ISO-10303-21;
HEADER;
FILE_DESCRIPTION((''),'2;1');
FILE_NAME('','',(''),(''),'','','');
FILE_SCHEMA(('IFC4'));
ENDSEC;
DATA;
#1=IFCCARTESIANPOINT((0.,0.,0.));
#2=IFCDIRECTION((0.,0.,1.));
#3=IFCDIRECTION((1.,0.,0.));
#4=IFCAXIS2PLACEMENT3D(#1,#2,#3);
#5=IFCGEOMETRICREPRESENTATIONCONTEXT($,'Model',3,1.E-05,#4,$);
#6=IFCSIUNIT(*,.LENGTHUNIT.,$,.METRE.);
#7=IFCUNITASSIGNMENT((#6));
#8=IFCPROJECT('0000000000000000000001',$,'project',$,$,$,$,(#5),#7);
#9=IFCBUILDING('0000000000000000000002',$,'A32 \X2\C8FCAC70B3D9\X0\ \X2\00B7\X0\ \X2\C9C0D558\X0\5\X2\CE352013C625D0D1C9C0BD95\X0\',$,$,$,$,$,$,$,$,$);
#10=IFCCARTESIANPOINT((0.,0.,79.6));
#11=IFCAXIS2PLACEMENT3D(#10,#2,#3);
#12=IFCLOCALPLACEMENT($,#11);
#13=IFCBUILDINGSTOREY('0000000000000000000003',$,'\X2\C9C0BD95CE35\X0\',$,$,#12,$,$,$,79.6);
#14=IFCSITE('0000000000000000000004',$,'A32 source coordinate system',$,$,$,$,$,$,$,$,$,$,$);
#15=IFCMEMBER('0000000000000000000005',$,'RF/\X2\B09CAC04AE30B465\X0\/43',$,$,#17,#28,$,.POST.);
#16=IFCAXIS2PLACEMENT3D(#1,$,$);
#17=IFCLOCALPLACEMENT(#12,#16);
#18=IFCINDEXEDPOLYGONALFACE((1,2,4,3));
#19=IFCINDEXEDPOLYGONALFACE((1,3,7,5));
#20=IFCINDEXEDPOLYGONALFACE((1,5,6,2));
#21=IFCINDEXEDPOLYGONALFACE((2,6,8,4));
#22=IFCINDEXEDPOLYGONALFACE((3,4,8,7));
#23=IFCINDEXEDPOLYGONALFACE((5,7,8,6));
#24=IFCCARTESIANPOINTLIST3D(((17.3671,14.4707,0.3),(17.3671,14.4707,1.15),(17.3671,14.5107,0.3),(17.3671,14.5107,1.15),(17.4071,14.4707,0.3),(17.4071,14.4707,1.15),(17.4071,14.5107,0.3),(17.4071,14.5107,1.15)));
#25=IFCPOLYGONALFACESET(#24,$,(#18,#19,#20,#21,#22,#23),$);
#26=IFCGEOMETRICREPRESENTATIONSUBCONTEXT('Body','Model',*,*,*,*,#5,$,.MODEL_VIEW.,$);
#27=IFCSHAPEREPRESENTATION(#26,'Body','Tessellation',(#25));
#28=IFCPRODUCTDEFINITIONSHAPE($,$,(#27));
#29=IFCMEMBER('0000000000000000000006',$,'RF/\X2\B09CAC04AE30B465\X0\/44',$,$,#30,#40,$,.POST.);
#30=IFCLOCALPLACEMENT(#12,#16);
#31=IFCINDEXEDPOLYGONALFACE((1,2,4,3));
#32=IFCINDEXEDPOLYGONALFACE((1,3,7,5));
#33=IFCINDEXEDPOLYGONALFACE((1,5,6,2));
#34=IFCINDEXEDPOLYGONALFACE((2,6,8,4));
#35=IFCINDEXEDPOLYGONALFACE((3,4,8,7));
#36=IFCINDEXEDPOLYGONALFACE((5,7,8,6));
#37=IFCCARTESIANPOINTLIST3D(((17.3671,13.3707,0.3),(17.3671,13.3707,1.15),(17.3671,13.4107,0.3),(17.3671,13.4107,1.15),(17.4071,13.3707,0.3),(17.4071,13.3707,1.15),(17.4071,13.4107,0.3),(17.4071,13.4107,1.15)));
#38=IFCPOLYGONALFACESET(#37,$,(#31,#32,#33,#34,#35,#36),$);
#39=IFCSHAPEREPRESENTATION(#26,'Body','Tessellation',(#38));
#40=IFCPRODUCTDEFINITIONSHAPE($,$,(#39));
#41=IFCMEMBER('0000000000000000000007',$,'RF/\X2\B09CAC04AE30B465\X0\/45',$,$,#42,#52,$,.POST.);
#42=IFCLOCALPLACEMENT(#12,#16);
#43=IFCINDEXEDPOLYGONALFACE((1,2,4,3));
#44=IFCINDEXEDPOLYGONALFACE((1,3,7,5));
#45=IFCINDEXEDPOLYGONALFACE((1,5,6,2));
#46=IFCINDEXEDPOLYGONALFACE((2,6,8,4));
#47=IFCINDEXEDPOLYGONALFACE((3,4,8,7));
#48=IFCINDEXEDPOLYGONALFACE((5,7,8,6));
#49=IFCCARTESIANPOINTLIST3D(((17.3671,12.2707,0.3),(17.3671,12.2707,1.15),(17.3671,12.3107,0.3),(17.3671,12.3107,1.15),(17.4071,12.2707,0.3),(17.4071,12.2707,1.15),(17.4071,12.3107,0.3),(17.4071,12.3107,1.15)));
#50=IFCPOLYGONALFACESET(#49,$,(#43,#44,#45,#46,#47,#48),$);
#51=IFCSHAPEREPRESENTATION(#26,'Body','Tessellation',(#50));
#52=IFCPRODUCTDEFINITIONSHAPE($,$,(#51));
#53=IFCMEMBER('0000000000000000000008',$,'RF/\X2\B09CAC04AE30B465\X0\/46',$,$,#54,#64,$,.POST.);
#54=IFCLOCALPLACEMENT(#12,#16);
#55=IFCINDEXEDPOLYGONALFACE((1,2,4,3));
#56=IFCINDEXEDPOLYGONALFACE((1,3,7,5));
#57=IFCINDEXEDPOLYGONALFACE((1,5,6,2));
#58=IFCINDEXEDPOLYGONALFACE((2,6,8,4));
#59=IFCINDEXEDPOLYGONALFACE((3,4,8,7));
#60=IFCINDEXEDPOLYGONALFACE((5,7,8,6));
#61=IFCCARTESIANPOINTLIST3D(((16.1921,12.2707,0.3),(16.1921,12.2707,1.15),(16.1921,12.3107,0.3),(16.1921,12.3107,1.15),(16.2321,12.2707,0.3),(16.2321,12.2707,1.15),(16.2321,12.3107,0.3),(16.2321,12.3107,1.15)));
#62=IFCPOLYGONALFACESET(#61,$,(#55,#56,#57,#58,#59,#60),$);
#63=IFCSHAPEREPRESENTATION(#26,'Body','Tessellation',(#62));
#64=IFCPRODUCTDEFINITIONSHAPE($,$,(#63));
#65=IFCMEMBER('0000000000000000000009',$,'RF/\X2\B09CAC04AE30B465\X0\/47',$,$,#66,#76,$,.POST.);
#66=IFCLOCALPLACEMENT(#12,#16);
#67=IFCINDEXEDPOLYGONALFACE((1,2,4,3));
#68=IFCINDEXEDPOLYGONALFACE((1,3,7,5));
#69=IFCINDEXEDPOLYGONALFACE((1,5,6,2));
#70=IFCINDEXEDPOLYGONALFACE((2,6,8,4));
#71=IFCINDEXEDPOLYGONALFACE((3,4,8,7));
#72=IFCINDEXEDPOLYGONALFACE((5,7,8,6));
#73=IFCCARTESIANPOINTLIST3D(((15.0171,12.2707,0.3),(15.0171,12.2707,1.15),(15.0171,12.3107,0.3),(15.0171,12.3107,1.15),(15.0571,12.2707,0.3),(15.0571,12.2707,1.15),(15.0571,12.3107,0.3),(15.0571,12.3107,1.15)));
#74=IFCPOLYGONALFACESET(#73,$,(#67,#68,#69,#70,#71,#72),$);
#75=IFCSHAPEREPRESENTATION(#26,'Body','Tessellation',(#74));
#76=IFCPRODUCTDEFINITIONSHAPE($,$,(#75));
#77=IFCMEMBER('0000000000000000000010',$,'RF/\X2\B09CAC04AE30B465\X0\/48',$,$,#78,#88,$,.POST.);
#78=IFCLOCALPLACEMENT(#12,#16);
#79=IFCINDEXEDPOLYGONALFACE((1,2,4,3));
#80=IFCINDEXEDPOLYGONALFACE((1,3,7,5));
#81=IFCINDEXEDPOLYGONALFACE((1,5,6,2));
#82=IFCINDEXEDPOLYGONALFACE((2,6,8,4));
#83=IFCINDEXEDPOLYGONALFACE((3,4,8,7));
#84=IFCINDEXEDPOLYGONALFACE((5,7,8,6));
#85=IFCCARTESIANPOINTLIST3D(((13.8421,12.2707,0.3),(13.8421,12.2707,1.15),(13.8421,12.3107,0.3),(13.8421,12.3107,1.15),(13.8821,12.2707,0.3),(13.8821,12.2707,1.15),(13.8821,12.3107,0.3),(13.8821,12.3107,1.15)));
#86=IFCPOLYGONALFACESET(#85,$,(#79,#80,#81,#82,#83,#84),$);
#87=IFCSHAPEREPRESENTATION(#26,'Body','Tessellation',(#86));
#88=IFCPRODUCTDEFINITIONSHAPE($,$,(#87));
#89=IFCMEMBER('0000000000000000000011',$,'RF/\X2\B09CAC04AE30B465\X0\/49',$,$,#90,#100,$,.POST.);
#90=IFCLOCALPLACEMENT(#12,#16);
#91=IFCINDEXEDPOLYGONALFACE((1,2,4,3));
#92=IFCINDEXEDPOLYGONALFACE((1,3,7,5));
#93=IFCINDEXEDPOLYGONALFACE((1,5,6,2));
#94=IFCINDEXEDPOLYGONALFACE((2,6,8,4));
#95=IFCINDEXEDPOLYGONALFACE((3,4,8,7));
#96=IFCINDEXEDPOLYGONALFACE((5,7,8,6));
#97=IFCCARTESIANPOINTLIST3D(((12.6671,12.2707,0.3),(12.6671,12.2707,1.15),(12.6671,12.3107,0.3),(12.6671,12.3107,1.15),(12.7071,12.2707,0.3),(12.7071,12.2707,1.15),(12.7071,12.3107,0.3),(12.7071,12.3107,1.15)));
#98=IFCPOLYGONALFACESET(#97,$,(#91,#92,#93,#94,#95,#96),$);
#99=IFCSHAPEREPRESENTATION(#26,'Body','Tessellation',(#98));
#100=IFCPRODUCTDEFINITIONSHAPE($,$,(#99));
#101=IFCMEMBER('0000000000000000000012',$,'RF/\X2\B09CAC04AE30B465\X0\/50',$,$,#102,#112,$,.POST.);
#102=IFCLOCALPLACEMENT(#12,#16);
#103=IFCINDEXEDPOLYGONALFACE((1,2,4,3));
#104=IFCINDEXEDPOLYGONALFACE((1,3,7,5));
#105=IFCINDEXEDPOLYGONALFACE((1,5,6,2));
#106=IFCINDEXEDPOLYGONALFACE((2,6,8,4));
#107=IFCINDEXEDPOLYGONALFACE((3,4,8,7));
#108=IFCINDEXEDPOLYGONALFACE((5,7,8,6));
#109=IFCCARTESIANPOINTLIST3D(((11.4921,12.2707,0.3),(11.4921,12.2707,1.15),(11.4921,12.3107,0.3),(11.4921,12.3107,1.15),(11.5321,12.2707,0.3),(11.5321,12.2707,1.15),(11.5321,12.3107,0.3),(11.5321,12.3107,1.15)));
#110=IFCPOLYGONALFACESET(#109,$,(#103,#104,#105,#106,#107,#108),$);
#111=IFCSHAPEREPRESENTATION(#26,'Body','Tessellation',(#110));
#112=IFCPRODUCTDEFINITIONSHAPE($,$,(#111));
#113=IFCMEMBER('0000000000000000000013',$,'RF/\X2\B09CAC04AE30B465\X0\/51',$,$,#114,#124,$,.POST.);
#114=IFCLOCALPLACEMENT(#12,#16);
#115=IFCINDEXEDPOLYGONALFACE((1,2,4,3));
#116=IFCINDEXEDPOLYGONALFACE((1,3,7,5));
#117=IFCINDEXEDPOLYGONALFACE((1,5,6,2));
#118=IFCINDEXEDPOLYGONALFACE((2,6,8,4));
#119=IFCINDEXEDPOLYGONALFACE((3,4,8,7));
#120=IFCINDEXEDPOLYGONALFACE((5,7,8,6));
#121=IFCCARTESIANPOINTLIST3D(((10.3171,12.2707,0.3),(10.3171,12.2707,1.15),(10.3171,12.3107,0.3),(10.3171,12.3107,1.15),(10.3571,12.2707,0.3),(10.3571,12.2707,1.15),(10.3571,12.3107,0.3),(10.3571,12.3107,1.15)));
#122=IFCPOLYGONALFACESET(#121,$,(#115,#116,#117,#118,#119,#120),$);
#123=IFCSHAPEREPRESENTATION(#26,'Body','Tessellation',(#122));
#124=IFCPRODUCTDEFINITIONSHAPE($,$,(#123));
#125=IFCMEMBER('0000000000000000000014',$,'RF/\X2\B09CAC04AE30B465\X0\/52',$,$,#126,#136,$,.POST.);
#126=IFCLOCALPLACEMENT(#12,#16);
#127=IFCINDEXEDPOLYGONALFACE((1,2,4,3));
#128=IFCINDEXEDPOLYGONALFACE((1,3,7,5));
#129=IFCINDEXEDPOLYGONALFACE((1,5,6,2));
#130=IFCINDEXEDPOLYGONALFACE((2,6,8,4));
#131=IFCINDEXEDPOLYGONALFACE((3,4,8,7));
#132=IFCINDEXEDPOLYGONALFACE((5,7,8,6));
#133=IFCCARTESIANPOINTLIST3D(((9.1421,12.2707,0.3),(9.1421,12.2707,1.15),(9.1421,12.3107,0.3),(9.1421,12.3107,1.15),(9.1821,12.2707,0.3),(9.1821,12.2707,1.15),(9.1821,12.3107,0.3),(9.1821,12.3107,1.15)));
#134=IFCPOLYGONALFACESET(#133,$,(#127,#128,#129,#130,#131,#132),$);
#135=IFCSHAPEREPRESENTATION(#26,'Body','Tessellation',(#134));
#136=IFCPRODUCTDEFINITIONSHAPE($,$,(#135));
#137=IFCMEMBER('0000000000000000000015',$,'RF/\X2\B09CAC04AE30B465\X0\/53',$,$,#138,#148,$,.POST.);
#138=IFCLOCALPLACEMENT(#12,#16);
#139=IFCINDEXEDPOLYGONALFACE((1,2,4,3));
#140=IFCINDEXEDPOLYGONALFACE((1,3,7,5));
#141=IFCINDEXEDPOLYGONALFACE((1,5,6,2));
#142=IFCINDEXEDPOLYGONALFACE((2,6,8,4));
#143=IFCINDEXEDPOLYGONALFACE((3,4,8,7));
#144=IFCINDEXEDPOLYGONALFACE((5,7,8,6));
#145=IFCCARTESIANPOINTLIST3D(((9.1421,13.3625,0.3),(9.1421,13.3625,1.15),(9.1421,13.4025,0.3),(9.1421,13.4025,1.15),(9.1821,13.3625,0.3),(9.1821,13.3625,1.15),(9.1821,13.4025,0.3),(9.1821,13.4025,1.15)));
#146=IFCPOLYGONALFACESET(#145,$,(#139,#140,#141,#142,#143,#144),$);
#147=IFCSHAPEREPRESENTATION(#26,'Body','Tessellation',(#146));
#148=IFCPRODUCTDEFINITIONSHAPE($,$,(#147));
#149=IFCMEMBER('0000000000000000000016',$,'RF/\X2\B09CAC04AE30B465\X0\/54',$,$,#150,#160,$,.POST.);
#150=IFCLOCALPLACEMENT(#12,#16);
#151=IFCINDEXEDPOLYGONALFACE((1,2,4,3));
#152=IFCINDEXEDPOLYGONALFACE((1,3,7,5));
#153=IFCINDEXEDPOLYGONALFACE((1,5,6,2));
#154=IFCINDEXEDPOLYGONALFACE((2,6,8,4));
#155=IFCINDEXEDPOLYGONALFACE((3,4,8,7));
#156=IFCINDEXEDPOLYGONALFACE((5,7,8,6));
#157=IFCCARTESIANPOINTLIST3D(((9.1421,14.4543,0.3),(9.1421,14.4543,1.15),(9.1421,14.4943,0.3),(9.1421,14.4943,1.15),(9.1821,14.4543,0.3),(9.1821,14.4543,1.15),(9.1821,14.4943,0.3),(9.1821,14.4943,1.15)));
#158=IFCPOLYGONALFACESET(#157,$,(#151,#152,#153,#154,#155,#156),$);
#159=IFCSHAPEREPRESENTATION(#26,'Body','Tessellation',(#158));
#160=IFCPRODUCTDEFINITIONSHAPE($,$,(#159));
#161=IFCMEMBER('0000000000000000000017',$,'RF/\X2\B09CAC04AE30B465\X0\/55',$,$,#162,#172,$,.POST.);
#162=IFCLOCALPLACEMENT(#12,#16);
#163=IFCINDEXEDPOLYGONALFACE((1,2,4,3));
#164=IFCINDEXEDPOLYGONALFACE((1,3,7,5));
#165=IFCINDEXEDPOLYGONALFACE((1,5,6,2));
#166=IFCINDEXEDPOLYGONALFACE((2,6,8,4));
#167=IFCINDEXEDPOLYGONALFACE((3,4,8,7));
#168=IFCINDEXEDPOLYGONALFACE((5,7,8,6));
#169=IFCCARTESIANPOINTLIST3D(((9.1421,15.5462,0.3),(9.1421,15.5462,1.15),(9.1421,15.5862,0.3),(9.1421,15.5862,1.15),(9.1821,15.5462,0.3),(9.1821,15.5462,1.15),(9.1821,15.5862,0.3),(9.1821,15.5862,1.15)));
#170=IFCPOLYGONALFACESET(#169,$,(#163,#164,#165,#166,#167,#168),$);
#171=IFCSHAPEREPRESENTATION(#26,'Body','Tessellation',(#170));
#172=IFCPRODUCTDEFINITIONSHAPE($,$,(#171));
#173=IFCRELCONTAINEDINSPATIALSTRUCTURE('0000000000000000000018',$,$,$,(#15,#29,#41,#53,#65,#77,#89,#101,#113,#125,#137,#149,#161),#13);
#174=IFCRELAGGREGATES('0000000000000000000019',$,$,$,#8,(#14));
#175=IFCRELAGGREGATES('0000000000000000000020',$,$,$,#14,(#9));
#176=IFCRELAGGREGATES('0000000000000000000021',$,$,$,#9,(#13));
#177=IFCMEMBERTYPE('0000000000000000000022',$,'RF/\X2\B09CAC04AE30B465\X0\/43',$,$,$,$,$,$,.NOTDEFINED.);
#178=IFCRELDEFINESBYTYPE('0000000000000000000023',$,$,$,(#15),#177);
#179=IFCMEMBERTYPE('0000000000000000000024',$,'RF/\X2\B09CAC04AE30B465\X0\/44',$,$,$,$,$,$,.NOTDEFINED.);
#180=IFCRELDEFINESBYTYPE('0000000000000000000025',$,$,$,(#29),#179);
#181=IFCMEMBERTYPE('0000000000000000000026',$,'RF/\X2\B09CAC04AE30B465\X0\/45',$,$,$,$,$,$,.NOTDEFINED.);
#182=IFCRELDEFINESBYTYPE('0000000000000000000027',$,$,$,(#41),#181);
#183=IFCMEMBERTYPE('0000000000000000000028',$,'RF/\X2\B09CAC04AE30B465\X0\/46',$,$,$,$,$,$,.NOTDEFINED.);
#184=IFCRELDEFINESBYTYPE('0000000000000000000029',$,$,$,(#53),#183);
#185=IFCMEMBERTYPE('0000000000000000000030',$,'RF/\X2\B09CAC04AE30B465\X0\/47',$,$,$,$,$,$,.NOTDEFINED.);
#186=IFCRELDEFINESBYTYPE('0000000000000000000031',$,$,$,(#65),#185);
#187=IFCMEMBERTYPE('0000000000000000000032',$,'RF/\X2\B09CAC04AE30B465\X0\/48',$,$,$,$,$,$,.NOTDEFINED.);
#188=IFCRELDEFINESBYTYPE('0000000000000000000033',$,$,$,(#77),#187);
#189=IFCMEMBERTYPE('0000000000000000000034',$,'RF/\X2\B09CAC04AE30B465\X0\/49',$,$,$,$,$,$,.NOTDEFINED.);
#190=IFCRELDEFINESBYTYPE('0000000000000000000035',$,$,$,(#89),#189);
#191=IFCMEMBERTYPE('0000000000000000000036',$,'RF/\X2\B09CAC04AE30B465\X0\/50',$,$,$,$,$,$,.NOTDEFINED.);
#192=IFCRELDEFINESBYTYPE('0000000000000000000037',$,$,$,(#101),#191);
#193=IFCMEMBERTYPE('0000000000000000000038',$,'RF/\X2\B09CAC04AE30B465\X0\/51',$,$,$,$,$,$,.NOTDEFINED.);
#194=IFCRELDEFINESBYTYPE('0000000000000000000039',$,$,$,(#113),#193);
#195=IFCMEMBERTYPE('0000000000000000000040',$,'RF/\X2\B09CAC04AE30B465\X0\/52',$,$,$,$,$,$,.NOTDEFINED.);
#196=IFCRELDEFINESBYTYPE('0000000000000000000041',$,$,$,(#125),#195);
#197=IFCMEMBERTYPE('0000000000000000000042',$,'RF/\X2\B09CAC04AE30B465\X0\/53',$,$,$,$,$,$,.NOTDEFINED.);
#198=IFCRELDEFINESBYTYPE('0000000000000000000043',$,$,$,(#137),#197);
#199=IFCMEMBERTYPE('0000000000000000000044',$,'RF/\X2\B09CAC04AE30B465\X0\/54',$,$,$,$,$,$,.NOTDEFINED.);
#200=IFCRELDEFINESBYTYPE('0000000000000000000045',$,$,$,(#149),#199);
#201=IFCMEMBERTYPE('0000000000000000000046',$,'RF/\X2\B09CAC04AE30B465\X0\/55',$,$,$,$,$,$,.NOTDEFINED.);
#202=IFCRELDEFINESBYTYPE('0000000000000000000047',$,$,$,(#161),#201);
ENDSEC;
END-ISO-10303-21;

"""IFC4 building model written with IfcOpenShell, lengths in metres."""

from ifc_helpers import new_model, si_unit, frame, origin, origin_with_axes, place, context, subcontext, project, spatial, polyline, outline, extrude, source, transform, mapped, type_object, type_shapes, element, save


model = new_model("IFC4")

# Units and contexts
model_context = context("Model", 3, precision=1e-05, world=origin_with_axes())
body_context = subcontext(model_context, "Body", "Model", "MODEL_VIEW")
ifc_project = project(units=[si_unit("LENGTHUNIT", "METRE")], contexts=[model_context])

# Site, building, storey
site = spatial("IfcSite", under=ifc_project, Name="A32 source coordinate system")
building = spatial("IfcBuilding", under=site, Name="A32 주거동 · 지하5층–옥탑지붕")
storey_placement = place(None, frame((0.0, 0.0, 79.6), z_axis=(0.0, 0.0, 1.0), x_axis=(1.0, 0.0, 0.0)))
storey = spatial("IfcBuildingStorey", under=building, at=storey_placement, Name="지붕층", Elevation=79.6)

# Members
member_type_1 = type_object("IfcMemberType", Name="RF/난간기둥/43", PredefinedType="NOTDEFINED")
shared_shape_1 = source(origin(), body_context, "Body", "SweptSolid", [
    extrude(outline(polyline([(17.4071, 14.4707), (17.3671, 14.4707), (17.3671, 14.5107), (17.4071, 14.5107), (17.4071, 14.4707)])), frame((0.0, 0.0, 0.3)), (0.0, 0.0, 1.0), 0.85),
])
type_shapes(member_type_1, [shared_shape_1])
member_1_placement = place(storey_placement, origin_with_axes())
element("IfcMember", 1, at=member_1_placement, inside=storey, type_object=member_type_1, Name="RF/난간기둥/43", PredefinedType="POST", context=body_context, shape_type="MappedRepresentation", body=[
    mapped(shared_shape_1, transform((0.0, 0.0, 0.0), scale=1.0)),
])
member_type_2 = type_object("IfcMemberType", Name="RF/난간기둥/44", PredefinedType="NOTDEFINED")
shared_shape_2 = source(origin(), body_context, "Body", "SweptSolid", [
    extrude(outline(polyline([(17.4071, 13.3707), (17.3671, 13.3707), (17.3671, 13.4107), (17.4071, 13.4107), (17.4071, 13.3707)])), frame((0.0, 0.0, 0.3)), (0.0, 0.0, 1.0), 0.85),
])
type_shapes(member_type_2, [shared_shape_2])
member_2_placement = place(storey_placement, origin_with_axes())
element("IfcMember", 2, at=member_2_placement, inside=storey, type_object=member_type_2, Name="RF/난간기둥/44", PredefinedType="POST", context=body_context, shape_type="MappedRepresentation", body=[
    mapped(shared_shape_2, transform((0.0, 0.0, 0.0), scale=1.0)),
])
member_type_3 = type_object("IfcMemberType", Name="RF/난간기둥/45", PredefinedType="NOTDEFINED")
shared_shape_3 = source(origin(), body_context, "Body", "SweptSolid", [
    extrude(outline(polyline([(17.4071, 12.2707), (17.3671, 12.2707), (17.3671, 12.3107), (17.4071, 12.3107), (17.4071, 12.2707)])), frame((0.0, 0.0, 0.3)), (0.0, 0.0, 1.0), 0.85),
])
type_shapes(member_type_3, [shared_shape_3])
member_3_placement = place(storey_placement, origin_with_axes())
element("IfcMember", 3, at=member_3_placement, inside=storey, type_object=member_type_3, Name="RF/난간기둥/45", PredefinedType="POST", context=body_context, shape_type="MappedRepresentation", body=[
    mapped(shared_shape_3, transform((0.0, 0.0, 0.0), scale=1.0)),
])
member_type_4 = type_object("IfcMemberType", Name="RF/난간기둥/46", PredefinedType="NOTDEFINED")
shared_shape_4 = source(origin(), body_context, "Body", "SweptSolid", [
    extrude(outline(polyline([(16.2321, 12.2707), (16.1921, 12.2707), (16.1921, 12.3107), (16.2321, 12.3107), (16.2321, 12.2707)])), frame((0.0, 0.0, 0.3)), (0.0, 0.0, 1.0), 0.85),
])
type_shapes(member_type_4, [shared_shape_4])
member_4_placement = place(storey_placement, origin_with_axes())
element("IfcMember", 4, at=member_4_placement, inside=storey, type_object=member_type_4, Name="RF/난간기둥/46", PredefinedType="POST", context=body_context, shape_type="MappedRepresentation", body=[
    mapped(shared_shape_4, transform((0.0, 0.0, 0.0), scale=1.0)),
])
member_type_5 = type_object("IfcMemberType", Name="RF/난간기둥/47", PredefinedType="NOTDEFINED")
shared_shape_5 = source(origin(), body_context, "Body", "SweptSolid", [
    extrude(outline(polyline([(15.0571, 12.2707), (15.0171, 12.2707), (15.0171, 12.3107), (15.0571, 12.3107), (15.0571, 12.2707)])), frame((0.0, 0.0, 0.3)), (0.0, 0.0, 1.0), 0.85),
])
type_shapes(member_type_5, [shared_shape_5])
member_5_placement = place(storey_placement, origin_with_axes())
element("IfcMember", 5, at=member_5_placement, inside=storey, type_object=member_type_5, Name="RF/난간기둥/47", PredefinedType="POST", context=body_context, shape_type="MappedRepresentation", body=[
    mapped(shared_shape_5, transform((0.0, 0.0, 0.0), scale=1.0)),
])
member_type_6 = type_object("IfcMemberType", Name="RF/난간기둥/48", PredefinedType="NOTDEFINED")
shared_shape_6 = source(origin(), body_context, "Body", "SweptSolid", [
    extrude(outline(polyline([(13.8821, 12.2707), (13.8421, 12.2707), (13.8421, 12.3107), (13.8821, 12.3107), (13.8821, 12.2707)])), frame((0.0, 0.0, 0.3)), (0.0, 0.0, 1.0), 0.85),
])
type_shapes(member_type_6, [shared_shape_6])
member_6_placement = place(storey_placement, origin_with_axes())
element("IfcMember", 6, at=member_6_placement, inside=storey, type_object=member_type_6, Name="RF/난간기둥/48", PredefinedType="POST", context=body_context, shape_type="MappedRepresentation", body=[
    mapped(shared_shape_6, transform((0.0, 0.0, 0.0), scale=1.0)),
])
member_type_7 = type_object("IfcMemberType", Name="RF/난간기둥/49", PredefinedType="NOTDEFINED")
shared_shape_7 = source(origin(), body_context, "Body", "SweptSolid", [
    extrude(outline(polyline([(12.7071, 12.2707), (12.6671, 12.2707), (12.6671, 12.3107), (12.7071, 12.3107), (12.7071, 12.2707)])), frame((0.0, 0.0, 0.3)), (0.0, 0.0, 1.0), 0.85),
])
type_shapes(member_type_7, [shared_shape_7])
member_7_placement = place(storey_placement, origin_with_axes())
element("IfcMember", 7, at=member_7_placement, inside=storey, type_object=member_type_7, Name="RF/난간기둥/49", PredefinedType="POST", context=body_context, shape_type="MappedRepresentation", body=[
    mapped(shared_shape_7, transform((0.0, 0.0, 0.0), scale=1.0)),
])
member_type_8 = type_object("IfcMemberType", Name="RF/난간기둥/50", PredefinedType="NOTDEFINED")
shared_shape_8 = source(origin(), body_context, "Body", "SweptSolid", [
    extrude(outline(polyline([(11.5321, 12.2707), (11.4921, 12.2707), (11.4921, 12.3107), (11.5321, 12.3107), (11.5321, 12.2707)])), frame((0.0, 0.0, 0.3)), (0.0, 0.0, 1.0), 0.85),
])
type_shapes(member_type_8, [shared_shape_8])
member_8_placement = place(storey_placement, origin_with_axes())
element("IfcMember", 8, at=member_8_placement, inside=storey, type_object=member_type_8, Name="RF/난간기둥/50", PredefinedType="POST", context=body_context, shape_type="MappedRepresentation", body=[
    mapped(shared_shape_8, transform((0.0, 0.0, 0.0), scale=1.0)),
])
member_type_9 = type_object("IfcMemberType", Name="RF/난간기둥/51", PredefinedType="NOTDEFINED")
shared_shape_9 = source(origin(), body_context, "Body", "SweptSolid", [
    extrude(outline(polyline([(10.3571, 12.2707), (10.3171, 12.2707), (10.3171, 12.3107), (10.3571, 12.3107), (10.3571, 12.2707)])), frame((0.0, 0.0, 0.3)), (0.0, 0.0, 1.0), 0.85),
])
type_shapes(member_type_9, [shared_shape_9])
member_9_placement = place(storey_placement, origin_with_axes())
element("IfcMember", 9, at=member_9_placement, inside=storey, type_object=member_type_9, Name="RF/난간기둥/51", PredefinedType="POST", context=body_context, shape_type="MappedRepresentation", body=[
    mapped(shared_shape_9, transform((0.0, 0.0, 0.0), scale=1.0)),
])
member_type_10 = type_object("IfcMemberType", Name="RF/난간기둥/52", PredefinedType="NOTDEFINED")
shared_shape_10 = source(origin(), body_context, "Body", "SweptSolid", [
    extrude(outline(polyline([(9.1821, 12.2707), (9.1421, 12.2707), (9.1421, 12.3107), (9.1821, 12.3107), (9.1821, 12.2707)])), frame((0.0, 0.0, 0.3)), (0.0, 0.0, 1.0), 0.85),
])
type_shapes(member_type_10, [shared_shape_10])
member_10_placement = place(storey_placement, origin_with_axes())
element("IfcMember", 10, at=member_10_placement, inside=storey, type_object=member_type_10, Name="RF/난간기둥/52", PredefinedType="POST", context=body_context, shape_type="MappedRepresentation", body=[
    mapped(shared_shape_10, transform((0.0, 0.0, 0.0), scale=1.0)),
])
member_type_11 = type_object("IfcMemberType", Name="RF/난간기둥/53", PredefinedType="NOTDEFINED")
shared_shape_11 = source(origin(), body_context, "Body", "SweptSolid", [
    extrude(outline(polyline([(9.1821, 13.3625), (9.1421, 13.3625), (9.1421, 13.4025), (9.1821, 13.4025), (9.1821, 13.3625)])), frame((0.0, 0.0, 0.3)), (0.0, 0.0, 1.0), 0.85),
])
type_shapes(member_type_11, [shared_shape_11])
member_11_placement = place(storey_placement, origin_with_axes())
element("IfcMember", 11, at=member_11_placement, inside=storey, type_object=member_type_11, Name="RF/난간기둥/53", PredefinedType="POST", context=body_context, shape_type="MappedRepresentation", body=[
    mapped(shared_shape_11, transform((0.0, 0.0, 0.0), scale=1.0)),
])
member_type_12 = type_object("IfcMemberType", Name="RF/난간기둥/54", PredefinedType="NOTDEFINED")
shared_shape_12 = source(origin(), body_context, "Body", "SweptSolid", [
    extrude(outline(polyline([(9.1821, 14.4543), (9.1421, 14.4543), (9.1421, 14.4943), (9.1821, 14.4943), (9.1821, 14.4543)])), frame((0.0, 0.0, 0.3)), (0.0, 0.0, 1.0), 0.85),
])
type_shapes(member_type_12, [shared_shape_12])
member_12_placement = place(storey_placement, origin_with_axes())
element("IfcMember", 12, at=member_12_placement, inside=storey, type_object=member_type_12, Name="RF/난간기둥/54", PredefinedType="POST", context=body_context, shape_type="MappedRepresentation", body=[
    mapped(shared_shape_12, transform((0.0, 0.0, 0.0), scale=1.0)),
])
member_type_13 = type_object("IfcMemberType", Name="RF/난간기둥/55", PredefinedType="NOTDEFINED")
shared_shape_13 = source(origin(), body_context, "Body", "SweptSolid", [
    extrude(outline(polyline([(9.1821, 15.5462), (9.1421, 15.5462), (9.1421, 15.5862), (9.1821, 15.5862), (9.1821, 15.5462)])), frame((0.0, 0.0, 0.3)), (0.0, 0.0, 1.0), 0.85),
])
type_shapes(member_type_13, [shared_shape_13])
member_13_placement = place(storey_placement, origin_with_axes())
element("IfcMember", 13, at=member_13_placement, inside=storey, type_object=member_type_13, Name="RF/난간기둥/55", PredefinedType="POST", context=body_context, shape_type="MappedRepresentation", body=[
    mapped(shared_shape_13, transform((0.0, 0.0, 0.0), scale=1.0)),
])

save(model, "model.ifc")
